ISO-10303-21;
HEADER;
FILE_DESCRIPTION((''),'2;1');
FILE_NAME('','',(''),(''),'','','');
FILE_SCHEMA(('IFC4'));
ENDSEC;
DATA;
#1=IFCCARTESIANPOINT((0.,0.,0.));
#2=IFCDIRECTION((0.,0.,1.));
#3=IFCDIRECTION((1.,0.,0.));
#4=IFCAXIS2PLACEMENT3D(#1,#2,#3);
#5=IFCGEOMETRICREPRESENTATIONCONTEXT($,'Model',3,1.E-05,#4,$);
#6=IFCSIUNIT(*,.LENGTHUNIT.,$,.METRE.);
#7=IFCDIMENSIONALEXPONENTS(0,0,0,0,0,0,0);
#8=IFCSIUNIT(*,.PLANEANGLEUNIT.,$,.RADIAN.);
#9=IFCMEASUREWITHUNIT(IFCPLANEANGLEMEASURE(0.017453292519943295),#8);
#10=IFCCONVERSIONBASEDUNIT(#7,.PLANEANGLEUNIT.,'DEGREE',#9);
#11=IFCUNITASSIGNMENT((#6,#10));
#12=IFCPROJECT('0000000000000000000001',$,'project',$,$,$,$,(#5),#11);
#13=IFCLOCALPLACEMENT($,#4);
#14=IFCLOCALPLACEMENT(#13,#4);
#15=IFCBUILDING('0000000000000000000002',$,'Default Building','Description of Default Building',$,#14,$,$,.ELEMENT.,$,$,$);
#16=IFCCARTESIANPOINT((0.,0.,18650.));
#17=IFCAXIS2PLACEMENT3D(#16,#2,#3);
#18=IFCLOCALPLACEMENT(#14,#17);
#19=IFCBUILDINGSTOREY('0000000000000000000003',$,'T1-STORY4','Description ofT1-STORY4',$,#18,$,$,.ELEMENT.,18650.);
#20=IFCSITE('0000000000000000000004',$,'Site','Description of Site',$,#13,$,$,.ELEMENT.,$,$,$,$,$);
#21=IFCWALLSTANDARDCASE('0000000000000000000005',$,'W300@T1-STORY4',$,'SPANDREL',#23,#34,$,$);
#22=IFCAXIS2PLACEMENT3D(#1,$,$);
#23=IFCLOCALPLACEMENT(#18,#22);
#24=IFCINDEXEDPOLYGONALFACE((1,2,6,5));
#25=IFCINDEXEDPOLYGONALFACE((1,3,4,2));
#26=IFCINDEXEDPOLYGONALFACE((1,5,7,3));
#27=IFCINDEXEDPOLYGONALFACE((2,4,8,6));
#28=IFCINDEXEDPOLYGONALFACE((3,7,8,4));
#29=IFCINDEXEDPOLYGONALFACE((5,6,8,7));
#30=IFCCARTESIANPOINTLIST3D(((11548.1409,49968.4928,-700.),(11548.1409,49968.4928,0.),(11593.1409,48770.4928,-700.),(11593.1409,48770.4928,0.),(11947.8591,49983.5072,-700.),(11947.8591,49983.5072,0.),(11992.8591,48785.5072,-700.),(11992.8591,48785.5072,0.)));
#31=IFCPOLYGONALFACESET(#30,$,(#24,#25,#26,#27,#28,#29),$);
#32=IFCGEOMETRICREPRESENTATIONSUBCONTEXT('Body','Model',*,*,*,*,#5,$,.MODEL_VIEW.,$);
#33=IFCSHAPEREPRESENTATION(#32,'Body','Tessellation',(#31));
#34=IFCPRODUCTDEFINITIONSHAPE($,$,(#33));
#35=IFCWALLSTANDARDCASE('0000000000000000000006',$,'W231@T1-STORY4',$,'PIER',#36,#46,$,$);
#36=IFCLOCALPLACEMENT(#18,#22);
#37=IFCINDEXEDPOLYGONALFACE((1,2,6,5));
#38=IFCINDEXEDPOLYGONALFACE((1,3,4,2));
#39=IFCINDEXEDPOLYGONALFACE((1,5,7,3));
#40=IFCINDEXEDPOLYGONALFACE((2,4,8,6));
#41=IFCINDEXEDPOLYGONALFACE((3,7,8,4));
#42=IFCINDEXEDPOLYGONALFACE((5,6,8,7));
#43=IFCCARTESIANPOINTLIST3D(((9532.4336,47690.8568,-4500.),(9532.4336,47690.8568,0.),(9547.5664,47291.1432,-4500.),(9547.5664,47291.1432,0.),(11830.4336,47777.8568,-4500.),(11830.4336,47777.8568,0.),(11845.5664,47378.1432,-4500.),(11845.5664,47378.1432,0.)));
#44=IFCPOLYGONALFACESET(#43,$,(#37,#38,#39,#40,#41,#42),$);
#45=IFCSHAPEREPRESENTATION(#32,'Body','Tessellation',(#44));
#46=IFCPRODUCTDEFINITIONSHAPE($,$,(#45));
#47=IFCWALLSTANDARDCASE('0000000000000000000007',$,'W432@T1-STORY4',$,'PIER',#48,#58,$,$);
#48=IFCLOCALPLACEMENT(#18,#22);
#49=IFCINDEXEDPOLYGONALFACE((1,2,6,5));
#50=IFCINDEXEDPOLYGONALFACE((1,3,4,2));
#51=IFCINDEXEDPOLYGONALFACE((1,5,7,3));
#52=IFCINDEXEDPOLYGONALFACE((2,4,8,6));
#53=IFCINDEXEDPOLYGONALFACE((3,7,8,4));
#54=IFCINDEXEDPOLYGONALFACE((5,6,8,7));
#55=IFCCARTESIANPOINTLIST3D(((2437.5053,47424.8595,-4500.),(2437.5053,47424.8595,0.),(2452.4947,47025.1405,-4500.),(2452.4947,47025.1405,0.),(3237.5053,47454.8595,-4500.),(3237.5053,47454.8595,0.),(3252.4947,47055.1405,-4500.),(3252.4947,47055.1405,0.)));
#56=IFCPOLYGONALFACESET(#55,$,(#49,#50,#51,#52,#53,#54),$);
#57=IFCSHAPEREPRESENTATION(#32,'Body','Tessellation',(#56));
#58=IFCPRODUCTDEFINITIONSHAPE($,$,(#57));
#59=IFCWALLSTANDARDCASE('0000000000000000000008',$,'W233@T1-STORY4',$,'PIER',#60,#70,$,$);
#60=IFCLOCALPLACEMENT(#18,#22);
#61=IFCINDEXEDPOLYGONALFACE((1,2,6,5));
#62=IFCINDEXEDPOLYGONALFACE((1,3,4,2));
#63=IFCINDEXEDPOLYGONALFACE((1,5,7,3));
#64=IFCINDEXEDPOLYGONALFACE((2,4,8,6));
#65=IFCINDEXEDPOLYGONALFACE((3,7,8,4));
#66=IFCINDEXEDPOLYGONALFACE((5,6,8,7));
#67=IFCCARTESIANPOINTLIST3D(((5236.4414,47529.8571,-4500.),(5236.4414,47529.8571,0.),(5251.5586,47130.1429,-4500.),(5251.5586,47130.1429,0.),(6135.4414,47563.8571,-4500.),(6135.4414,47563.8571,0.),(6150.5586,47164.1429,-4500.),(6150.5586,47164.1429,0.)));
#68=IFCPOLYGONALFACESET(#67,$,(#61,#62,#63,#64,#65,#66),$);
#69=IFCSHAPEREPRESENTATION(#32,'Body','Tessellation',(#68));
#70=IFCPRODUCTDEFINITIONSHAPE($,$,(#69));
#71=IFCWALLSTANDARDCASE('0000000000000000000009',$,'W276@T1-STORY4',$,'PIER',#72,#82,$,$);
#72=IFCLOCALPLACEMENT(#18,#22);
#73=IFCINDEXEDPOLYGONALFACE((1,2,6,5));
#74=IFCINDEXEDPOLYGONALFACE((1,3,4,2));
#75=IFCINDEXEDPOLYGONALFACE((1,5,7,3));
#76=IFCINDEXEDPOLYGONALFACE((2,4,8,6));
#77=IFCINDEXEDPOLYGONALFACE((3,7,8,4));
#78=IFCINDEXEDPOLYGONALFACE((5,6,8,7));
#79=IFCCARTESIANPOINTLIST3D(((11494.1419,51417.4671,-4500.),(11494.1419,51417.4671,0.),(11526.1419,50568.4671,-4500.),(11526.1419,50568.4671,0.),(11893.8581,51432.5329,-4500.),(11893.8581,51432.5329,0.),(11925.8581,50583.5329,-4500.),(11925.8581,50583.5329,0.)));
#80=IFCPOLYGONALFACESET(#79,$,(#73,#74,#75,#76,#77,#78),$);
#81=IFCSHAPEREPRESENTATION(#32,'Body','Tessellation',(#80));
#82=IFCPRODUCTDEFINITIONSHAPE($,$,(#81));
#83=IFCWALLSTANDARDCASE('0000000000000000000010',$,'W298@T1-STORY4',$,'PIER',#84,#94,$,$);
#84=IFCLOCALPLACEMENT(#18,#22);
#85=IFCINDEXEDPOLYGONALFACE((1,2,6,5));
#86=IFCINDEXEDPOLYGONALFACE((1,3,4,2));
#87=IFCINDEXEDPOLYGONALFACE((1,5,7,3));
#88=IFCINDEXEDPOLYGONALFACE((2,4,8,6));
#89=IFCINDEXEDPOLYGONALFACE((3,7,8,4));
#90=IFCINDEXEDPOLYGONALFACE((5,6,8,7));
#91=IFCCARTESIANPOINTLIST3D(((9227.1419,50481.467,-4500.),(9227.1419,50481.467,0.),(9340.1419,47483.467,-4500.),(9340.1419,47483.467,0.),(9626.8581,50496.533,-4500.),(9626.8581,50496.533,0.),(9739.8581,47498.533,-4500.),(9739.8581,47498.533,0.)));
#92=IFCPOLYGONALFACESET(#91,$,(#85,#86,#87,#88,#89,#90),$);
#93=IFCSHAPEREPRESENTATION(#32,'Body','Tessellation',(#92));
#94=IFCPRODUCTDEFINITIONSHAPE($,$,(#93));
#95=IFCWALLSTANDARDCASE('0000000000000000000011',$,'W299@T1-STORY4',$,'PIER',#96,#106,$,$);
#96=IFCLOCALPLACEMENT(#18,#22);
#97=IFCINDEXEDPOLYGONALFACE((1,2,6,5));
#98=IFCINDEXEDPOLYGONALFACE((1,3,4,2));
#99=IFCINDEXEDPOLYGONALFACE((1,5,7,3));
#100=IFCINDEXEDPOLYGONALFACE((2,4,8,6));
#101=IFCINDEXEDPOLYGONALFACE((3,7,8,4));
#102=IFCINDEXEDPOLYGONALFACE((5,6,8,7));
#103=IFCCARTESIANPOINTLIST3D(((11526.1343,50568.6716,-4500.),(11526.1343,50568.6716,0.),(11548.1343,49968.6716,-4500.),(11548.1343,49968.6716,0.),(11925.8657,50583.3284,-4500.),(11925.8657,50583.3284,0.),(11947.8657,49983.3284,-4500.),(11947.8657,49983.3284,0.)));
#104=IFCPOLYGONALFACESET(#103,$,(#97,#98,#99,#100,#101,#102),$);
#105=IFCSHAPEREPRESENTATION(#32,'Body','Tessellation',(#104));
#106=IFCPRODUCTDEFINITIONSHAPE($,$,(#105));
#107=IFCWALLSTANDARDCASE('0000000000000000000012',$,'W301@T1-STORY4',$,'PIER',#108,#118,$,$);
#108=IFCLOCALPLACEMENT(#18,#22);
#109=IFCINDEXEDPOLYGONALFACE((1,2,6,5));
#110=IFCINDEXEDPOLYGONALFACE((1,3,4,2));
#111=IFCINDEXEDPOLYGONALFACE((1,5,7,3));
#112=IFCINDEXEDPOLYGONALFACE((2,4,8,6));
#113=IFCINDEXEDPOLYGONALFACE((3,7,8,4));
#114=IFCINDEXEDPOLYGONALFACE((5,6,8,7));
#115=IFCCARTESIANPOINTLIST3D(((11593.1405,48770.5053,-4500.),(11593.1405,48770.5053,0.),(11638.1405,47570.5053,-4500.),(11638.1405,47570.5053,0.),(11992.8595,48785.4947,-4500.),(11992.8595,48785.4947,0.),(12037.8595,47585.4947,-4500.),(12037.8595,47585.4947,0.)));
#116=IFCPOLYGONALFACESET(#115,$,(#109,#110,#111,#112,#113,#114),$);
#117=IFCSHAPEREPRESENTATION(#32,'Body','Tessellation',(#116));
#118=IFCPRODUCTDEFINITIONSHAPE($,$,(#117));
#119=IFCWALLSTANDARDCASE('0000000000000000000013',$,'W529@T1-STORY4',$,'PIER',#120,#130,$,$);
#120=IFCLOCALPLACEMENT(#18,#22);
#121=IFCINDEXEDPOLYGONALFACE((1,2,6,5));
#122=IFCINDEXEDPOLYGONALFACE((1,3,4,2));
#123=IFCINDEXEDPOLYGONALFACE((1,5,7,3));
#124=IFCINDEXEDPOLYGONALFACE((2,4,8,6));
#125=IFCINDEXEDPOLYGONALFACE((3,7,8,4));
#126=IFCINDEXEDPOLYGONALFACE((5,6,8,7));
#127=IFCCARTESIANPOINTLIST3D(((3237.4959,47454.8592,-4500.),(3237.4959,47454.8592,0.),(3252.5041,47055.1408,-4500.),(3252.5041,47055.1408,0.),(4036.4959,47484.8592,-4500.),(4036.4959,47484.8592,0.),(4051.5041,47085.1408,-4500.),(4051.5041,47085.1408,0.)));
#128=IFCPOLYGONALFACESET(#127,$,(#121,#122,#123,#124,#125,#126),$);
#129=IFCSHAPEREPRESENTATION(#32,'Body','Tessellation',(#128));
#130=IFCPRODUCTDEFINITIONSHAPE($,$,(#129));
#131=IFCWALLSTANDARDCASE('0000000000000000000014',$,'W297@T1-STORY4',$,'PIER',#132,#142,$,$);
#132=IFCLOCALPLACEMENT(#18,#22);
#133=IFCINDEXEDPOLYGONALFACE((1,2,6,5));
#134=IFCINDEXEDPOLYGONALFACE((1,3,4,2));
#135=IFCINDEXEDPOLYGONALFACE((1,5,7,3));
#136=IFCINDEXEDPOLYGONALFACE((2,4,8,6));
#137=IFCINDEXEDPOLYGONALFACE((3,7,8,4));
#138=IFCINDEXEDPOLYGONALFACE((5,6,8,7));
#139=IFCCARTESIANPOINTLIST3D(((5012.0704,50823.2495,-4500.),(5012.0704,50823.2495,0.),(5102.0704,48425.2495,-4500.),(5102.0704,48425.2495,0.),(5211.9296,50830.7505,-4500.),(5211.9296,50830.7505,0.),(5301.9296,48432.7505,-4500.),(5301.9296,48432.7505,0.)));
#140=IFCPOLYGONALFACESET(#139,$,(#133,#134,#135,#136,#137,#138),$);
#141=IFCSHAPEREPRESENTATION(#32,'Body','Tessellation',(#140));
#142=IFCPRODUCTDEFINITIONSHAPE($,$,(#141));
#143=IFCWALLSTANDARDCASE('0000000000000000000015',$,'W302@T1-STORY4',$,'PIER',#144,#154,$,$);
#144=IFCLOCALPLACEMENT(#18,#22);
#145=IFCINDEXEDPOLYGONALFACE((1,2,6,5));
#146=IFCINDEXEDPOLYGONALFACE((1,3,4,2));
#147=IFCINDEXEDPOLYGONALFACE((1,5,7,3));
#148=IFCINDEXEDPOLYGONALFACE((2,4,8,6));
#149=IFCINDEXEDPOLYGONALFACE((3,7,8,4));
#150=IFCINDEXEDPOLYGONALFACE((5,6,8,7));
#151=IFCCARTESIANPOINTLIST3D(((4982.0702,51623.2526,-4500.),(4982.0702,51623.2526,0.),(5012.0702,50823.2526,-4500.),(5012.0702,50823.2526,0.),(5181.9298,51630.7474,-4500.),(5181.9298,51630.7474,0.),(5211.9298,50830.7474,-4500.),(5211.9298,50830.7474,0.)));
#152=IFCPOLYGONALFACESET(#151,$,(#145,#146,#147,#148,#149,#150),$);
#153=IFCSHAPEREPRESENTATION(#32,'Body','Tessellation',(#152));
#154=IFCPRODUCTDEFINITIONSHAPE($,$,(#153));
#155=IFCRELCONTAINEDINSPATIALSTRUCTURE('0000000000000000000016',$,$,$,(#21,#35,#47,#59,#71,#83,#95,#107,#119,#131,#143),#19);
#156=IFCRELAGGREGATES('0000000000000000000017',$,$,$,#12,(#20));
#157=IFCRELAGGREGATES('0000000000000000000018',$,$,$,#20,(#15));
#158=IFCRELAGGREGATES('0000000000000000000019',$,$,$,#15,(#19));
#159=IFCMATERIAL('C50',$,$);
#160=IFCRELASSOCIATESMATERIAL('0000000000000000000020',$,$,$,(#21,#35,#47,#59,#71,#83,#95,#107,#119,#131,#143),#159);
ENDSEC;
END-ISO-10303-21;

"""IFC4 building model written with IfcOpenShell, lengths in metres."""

from ifc_helpers import new_model, entity, si_unit, converted_unit, frame, origin_with_axes, place, context, subcontext, project, spatial, indexed_curve, outline, extrude, material, element, save


model = new_model("IFC4")

# Units and contexts
model_context = context("Model", 3, precision=1e-05, world=origin_with_axes())
body_context = subcontext(model_context, "Body", "Model", "MODEL_VIEW")
ifc_project = project(units=[si_unit("LENGTHUNIT", "METRE"), converted_unit("PLANEANGLEUNIT", "DEGREE", entity("IfcPlaneAngleMeasure", 0.017453292519943295), si_unit("PLANEANGLEUNIT", "RADIAN"), dimensions=[0, 0, 0, 0, 0, 0, 0])], contexts=[model_context])

# Site, building, storey
site_placement = place(None, origin_with_axes())
site = spatial("IfcSite", under=ifc_project, at=site_placement, Name="Site", Description="Description of Site", CompositionType="ELEMENT")
building_placement = place(site_placement, origin_with_axes())
building = spatial("IfcBuilding", under=site, at=building_placement, Name="Default Building", Description="Description of Default Building", CompositionType="ELEMENT")
storey_placement = place(building_placement, frame((0.0, 0.0, 18650.0), z_axis=(0.0, 0.0, 1.0), x_axis=(1.0, 0.0, 0.0)))
storey = spatial("IfcBuildingStorey", under=building, at=storey_placement, Name="T1-STORY4", Description="Description ofT1-STORY4", CompositionType="ELEMENT", Elevation=18650.0)

# Shared definitions
ifc_material_1 = material(Name="C50")

# Walls
wall_1_placement = place(storey_placement, frame((11748.0, 49976.0, -700.0), z_axis=(0.0, 0.0, 1.0), x_axis=(0.037536, -0.999295, 0.0)))
element("IfcWallStandardCase", 1, at=wall_1_placement, inside=storey, material=ifc_material_1, Name="W300@T1-STORY4", ObjectType="SPANDREL", context=body_context, shape_type="SweptSolid", body=[
    extrude(outline(indexed_curve([(0.0, -200.0), (0.0, 200.0), (1198.8449, 200.0), (1198.8449, -200.0), (0.0, -200.0)], self_intersect=False)), origin_with_axes(), (0.0, 0.0, 1.0), 700.0),
])
wall_2_placement = place(storey_placement, frame((9540.0, 47491.0, -4500.0), z_axis=(0.0, 0.0, 1.0), x_axis=(0.999284, 0.037832, 0.0)))
element("IfcWallStandardCase", 2, at=wall_2_placement, inside=storey, material=ifc_material_1, Name="W231@T1-STORY4", ObjectType="PIER", context=body_context, shape_type="SweptSolid", body=[
    extrude(outline(indexed_curve([(0.0, -200.0), (0.0, 200.0), (2299.6463, 200.0), (2299.6463, -200.0), (0.0, -200.0)], self_intersect=False)), origin_with_axes(), (0.0, 0.0, 1.0), 4500.0),
])
wall_3_placement = place(storey_placement, frame((2445.0, 47225.0, -4500.0), z_axis=(0.0, 0.0, 1.0), x_axis=(0.999298, 0.037474, 0.0)))
element("IfcWallStandardCase", 3, at=wall_3_placement, inside=storey, material=ifc_material_1, Name="W432@T1-STORY4", ObjectType="PIER", context=body_context, shape_type="SweptSolid", body=[
    extrude(outline(indexed_curve([(0.0, -200.0), (0.0, 200.0), (800.5623, 200.0), (800.5623, -200.0), (0.0, -200.0)], self_intersect=False)), origin_with_axes(), (0.0, 0.0, 1.0), 4500.0),
])
wall_4_placement = place(storey_placement, frame((5244.0, 47330.0, -4500.0), z_axis=(0.0, 0.0, 1.0), x_axis=(0.999286, 0.037793, 0.0)))
element("IfcWallStandardCase", 4, at=wall_4_placement, inside=storey, material=ifc_material_1, Name="W233@T1-STORY4", ObjectType="PIER", context=body_context, shape_type="SweptSolid", body=[
    extrude(outline(indexed_curve([(0.0, -200.0), (0.0, 200.0), (899.6427, 200.0), (899.6427, -200.0), (0.0, -200.0)], self_intersect=False)), origin_with_axes(), (0.0, 0.0, 1.0), 4500.0),
])
wall_5_placement = place(storey_placement, frame((11694.0, 51425.0, -4500.0), z_axis=(0.0, 0.0, 1.0), x_axis=(0.037665, -0.99929, 0.0)))
element("IfcWallStandardCase", 5, at=wall_5_placement, inside=storey, material=ifc_material_1, Name="W276@T1-STORY4", ObjectType="PIER", context=body_context, shape_type="SweptSolid", body=[
    extrude(outline(indexed_curve([(0.0, -200.0), (0.0, 200.0), (849.6028, 200.0), (849.6028, -200.0), (0.0, -200.0)], self_intersect=False)), origin_with_axes(), (0.0, 0.0, 1.0), 4500.0),
])
wall_6_placement = place(storey_placement, frame((9427.0, 50489.0, -4500.0), z_axis=(0.0, 0.0, 1.0), x_axis=(0.037665, -0.99929, 0.0)))
element("IfcWallStandardCase", 6, at=wall_6_placement, inside=storey, material=ifc_material_1, Name="W298@T1-STORY4", ObjectType="PIER", context=body_context, shape_type="SweptSolid", body=[
    extrude(outline(indexed_curve([(0.0, -200.0), (0.0, 200.0), (3000.1288, 200.0), (3000.1288, -200.0), (0.0, -200.0)], self_intersect=False)), origin_with_axes(), (0.0, 0.0, 1.0), 4500.0),
])
wall_7_placement = place(storey_placement, frame((11726.0, 50576.0, -4500.0), z_axis=(0.0, 0.0, 1.0), x_axis=(0.036642, -0.999328, 0.0)))
element("IfcWallStandardCase", 7, at=wall_7_placement, inside=storey, material=ifc_material_1, Name="W299@T1-STORY4", ObjectType="PIER", context=body_context, shape_type="SweptSolid", body=[
    extrude(outline(indexed_curve([(0.0, -200.0), (0.0, 200.0), (600.4032, 200.0), (600.4032, -200.0), (0.0, -200.0)], self_intersect=False)), origin_with_axes(), (0.0, 0.0, 1.0), 4500.0),
])
wall_8_placement = place(storey_placement, frame((11793.0, 48778.0, -4500.0), z_axis=(0.0, 0.0, 1.0), x_axis=(0.037474, -0.999298, 0.0)))
element("IfcWallStandardCase", 8, at=wall_8_placement, inside=storey, material=ifc_material_1, Name="W301@T1-STORY4", ObjectType="PIER", context=body_context, shape_type="SweptSolid", body=[
    extrude(outline(indexed_curve([(0.0, -200.0), (0.0, 200.0), (1200.8435, 200.0), (1200.8435, -200.0), (0.0, -200.0)], self_intersect=False)), origin_with_axes(), (0.0, 0.0, 1.0), 4500.0),
])
wall_9_placement = place(storey_placement, frame((3245.0, 47255.0, -4500.0), z_axis=(0.0, 0.0, 1.0), x_axis=(0.999296, 0.03752, 0.0)))
element("IfcWallStandardCase", 9, at=wall_9_placement, inside=storey, material=ifc_material_1, Name="W529@T1-STORY4", ObjectType="PIER", context=body_context, shape_type="SweptSolid", body=[
    extrude(outline(indexed_curve([(0.0, -200.0), (0.0, 200.0), (799.563, 200.0), (799.563, -200.0), (0.0, -200.0)], self_intersect=False)), origin_with_axes(), (0.0, 0.0, 1.0), 4500.0),
])
wall_10_placement = place(storey_placement, frame((5112.0, 50827.0, -4500.0), z_axis=(0.0, 0.0, 1.0), x_axis=(0.037505, -0.999296, 0.0)))
element("IfcWallStandardCase", 10, at=wall_10_placement, inside=storey, material=ifc_material_1, Name="W297@T1-STORY4", ObjectType="PIER", context=body_context, shape_type="SweptSolid", body=[
    extrude(outline(indexed_curve([(0.0, -100.0), (0.0, 100.0), (2399.6883, 100.0), (2399.6883, -100.0), (0.0, -100.0)], self_intersect=False)), origin_with_axes(), (0.0, 0.0, 1.0), 4500.0),
])
wall_11_placement = place(storey_placement, frame((5082.0, 51627.0, -4500.0), z_axis=(0.0, 0.0, 1.0), x_axis=(0.037474, -0.999298, 0.0)))
element("IfcWallStandardCase", 11, at=wall_11_placement, inside=storey, material=ifc_material_1, Name="W302@T1-STORY4", ObjectType="PIER", context=body_context, shape_type="SweptSolid", body=[
    extrude(outline(indexed_curve([(0.0, -100.0), (0.0, 100.0), (800.5623, 100.0), (800.5623, -100.0), (0.0, -100.0)], self_intersect=False)), origin_with_axes(), (0.0, 0.0, 1.0), 4500.0),
])

save(model, "model.ifc")
